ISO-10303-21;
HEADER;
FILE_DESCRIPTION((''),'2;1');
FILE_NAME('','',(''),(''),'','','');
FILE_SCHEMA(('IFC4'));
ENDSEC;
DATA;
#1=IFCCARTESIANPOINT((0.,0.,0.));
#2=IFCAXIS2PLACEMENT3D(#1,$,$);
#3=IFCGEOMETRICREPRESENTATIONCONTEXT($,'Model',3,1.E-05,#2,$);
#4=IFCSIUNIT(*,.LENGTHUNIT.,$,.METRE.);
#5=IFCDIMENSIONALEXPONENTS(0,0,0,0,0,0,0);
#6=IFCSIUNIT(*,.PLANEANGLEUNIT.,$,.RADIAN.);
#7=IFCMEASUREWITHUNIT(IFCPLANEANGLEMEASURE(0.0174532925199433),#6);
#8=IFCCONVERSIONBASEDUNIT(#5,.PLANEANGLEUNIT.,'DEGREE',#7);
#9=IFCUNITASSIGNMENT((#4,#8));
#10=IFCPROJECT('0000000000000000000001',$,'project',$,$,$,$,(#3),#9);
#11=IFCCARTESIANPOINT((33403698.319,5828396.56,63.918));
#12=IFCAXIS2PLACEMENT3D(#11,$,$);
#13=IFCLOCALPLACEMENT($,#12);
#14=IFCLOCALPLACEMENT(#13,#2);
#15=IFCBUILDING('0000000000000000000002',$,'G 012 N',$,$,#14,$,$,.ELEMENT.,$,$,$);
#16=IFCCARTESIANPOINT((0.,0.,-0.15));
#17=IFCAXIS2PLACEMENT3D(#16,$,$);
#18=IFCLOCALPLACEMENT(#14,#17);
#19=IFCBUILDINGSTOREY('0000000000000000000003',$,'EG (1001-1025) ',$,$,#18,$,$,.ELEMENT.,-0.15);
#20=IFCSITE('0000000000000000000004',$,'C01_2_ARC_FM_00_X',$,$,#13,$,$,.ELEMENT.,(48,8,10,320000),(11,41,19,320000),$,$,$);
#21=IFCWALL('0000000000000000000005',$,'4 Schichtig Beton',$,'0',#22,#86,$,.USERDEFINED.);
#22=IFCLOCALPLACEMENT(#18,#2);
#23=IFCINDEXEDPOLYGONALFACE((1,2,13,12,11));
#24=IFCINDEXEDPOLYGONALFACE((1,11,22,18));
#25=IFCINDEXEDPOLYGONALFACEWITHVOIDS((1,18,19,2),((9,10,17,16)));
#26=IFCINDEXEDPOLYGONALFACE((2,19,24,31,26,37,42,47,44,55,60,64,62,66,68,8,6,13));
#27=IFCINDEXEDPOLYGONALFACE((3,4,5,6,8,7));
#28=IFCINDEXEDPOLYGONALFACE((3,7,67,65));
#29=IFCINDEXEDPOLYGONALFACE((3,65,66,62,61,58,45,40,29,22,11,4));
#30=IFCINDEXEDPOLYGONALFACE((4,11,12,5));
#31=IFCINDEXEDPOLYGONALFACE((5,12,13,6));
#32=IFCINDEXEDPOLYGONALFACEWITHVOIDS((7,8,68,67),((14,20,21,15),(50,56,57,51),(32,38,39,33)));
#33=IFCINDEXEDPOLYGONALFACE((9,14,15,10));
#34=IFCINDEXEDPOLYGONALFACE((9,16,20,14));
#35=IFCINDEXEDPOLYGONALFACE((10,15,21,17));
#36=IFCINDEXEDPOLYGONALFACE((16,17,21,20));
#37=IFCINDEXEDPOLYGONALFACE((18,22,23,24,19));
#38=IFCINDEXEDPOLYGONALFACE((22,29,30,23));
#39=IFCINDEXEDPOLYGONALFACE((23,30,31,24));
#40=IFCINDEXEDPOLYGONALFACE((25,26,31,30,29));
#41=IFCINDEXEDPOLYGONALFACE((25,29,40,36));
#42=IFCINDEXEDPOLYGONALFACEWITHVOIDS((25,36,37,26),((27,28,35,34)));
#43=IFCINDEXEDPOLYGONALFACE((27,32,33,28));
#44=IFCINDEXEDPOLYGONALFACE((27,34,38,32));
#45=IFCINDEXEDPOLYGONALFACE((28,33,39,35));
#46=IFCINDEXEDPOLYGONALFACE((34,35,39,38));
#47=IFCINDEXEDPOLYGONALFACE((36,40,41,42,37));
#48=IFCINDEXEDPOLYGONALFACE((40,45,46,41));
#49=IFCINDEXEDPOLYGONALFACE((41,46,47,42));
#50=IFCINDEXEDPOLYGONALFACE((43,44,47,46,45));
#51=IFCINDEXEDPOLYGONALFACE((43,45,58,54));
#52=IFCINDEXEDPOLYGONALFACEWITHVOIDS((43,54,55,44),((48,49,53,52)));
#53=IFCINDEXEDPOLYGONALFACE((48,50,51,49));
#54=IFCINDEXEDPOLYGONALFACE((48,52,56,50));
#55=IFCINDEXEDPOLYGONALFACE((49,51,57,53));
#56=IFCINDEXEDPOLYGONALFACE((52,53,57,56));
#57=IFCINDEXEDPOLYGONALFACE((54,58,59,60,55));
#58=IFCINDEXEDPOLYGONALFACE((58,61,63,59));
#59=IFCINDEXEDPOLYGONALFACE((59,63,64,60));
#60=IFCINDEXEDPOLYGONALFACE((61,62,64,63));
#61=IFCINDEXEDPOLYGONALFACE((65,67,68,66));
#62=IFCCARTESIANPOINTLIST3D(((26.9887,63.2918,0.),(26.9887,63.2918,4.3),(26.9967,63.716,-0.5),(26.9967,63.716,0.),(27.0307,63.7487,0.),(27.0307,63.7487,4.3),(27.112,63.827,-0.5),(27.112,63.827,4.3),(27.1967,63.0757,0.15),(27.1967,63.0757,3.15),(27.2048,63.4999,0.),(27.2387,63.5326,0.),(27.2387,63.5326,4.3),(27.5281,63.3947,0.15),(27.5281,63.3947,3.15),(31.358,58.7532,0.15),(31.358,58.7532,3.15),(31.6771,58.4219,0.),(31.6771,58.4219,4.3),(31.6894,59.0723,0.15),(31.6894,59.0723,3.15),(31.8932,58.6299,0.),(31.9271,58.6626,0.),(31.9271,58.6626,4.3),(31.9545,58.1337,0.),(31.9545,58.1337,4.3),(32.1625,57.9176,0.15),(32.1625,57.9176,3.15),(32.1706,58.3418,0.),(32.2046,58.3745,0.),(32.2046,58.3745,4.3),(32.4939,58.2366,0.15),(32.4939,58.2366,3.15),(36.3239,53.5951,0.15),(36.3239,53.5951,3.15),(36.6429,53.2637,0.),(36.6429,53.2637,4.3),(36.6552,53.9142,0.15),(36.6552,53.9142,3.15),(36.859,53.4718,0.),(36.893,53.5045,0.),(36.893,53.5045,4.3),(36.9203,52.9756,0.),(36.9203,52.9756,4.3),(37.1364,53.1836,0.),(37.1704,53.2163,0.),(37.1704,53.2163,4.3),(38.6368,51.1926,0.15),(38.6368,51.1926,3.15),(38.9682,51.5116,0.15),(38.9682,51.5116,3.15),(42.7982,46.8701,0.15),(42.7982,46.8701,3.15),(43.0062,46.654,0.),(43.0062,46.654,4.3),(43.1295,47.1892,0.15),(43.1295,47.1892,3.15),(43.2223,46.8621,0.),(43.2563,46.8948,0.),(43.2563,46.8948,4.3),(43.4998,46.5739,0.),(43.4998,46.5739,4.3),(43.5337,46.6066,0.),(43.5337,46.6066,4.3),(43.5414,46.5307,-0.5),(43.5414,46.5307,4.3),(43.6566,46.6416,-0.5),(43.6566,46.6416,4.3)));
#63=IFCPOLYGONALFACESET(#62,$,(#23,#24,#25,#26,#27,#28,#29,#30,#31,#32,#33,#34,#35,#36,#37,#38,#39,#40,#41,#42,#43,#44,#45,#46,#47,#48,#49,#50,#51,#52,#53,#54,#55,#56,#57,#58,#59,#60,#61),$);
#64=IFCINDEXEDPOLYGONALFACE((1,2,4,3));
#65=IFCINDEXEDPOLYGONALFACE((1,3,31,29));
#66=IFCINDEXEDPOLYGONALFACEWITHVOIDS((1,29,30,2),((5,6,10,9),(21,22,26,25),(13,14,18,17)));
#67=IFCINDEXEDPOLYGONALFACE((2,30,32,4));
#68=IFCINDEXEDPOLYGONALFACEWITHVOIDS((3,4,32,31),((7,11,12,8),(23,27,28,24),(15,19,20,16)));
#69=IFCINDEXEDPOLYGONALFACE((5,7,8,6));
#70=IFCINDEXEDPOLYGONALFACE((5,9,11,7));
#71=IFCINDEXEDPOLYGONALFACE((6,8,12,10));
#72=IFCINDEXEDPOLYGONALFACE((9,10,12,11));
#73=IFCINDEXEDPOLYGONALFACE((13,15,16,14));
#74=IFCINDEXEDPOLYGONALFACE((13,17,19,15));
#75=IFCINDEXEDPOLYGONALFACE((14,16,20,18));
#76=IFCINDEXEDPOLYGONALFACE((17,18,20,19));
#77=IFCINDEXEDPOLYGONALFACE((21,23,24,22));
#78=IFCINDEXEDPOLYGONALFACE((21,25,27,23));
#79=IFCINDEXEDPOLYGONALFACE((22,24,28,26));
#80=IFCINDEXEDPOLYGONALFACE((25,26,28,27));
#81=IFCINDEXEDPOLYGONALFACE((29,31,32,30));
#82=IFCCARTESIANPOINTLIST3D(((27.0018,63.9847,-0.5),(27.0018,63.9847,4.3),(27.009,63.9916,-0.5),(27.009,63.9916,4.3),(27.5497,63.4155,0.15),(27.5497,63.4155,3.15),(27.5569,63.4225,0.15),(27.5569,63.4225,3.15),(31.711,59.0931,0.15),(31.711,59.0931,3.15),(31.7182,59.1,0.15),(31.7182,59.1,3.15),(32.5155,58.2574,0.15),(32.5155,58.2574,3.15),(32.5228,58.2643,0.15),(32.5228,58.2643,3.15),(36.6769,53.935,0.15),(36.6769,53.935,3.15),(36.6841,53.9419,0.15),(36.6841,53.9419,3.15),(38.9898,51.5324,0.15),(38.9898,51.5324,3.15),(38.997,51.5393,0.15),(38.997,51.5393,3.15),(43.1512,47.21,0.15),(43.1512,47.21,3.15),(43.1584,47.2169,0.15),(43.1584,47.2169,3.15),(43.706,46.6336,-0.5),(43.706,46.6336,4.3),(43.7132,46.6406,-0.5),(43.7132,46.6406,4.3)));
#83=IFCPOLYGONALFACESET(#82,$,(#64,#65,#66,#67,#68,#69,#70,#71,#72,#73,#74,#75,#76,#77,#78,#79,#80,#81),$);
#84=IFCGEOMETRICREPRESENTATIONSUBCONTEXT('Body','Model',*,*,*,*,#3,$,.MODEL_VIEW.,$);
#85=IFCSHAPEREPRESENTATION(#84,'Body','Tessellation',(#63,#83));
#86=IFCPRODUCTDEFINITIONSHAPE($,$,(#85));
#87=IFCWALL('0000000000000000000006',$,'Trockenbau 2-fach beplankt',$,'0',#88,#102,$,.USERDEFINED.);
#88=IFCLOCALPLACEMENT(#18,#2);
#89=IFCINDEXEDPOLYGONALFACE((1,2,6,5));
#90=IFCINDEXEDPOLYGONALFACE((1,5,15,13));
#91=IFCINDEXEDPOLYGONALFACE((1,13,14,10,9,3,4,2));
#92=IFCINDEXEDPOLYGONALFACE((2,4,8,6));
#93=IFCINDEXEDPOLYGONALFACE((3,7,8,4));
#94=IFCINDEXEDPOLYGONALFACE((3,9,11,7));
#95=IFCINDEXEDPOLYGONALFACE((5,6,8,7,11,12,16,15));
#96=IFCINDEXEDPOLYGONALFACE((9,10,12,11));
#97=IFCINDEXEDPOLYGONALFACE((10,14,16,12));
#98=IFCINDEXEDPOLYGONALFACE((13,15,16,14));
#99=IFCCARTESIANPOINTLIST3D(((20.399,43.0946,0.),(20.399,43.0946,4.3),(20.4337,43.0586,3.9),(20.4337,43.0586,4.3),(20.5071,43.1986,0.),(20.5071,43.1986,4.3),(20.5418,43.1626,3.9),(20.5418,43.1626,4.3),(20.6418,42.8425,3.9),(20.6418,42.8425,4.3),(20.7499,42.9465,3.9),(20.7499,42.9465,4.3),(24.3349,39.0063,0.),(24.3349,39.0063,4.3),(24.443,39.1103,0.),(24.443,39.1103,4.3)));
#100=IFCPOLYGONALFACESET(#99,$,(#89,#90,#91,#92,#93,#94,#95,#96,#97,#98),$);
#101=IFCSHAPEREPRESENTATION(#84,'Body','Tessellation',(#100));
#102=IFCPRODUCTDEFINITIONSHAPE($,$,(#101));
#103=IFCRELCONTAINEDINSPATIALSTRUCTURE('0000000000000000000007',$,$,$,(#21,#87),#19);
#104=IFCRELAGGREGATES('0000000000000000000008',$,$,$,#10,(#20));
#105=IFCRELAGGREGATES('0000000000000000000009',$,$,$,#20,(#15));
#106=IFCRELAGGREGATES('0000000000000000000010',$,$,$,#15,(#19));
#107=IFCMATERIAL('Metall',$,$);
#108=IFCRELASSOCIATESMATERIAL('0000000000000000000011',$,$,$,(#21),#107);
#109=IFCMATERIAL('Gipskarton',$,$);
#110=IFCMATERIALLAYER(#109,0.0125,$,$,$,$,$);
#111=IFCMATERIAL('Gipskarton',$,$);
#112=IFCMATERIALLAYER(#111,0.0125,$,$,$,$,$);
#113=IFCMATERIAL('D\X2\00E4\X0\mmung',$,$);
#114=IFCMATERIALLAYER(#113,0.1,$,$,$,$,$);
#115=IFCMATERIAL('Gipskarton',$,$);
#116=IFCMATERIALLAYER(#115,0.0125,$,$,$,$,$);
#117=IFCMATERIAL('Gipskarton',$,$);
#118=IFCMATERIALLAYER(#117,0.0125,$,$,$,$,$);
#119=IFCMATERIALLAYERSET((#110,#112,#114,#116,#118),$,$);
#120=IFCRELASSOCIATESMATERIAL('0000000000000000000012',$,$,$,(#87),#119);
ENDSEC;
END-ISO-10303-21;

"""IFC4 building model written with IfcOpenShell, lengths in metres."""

from ifc_helpers import new_model, entity, si_unit, converted_unit, frame, frame_2d, origin, origin_with_axes, place, context, subcontext, project, spatial, polyline, rectangle, outline, extrude, clip, bounded_halfspace, material, layer, layer_set, layer_usage, element, save


model = new_model("IFC4")

# Units and contexts
model_context = context("Model", 3, precision=1e-05, world=origin())
body_context = subcontext(model_context, "Body", "Model", "MODEL_VIEW")
ifc_project = project(units=[si_unit("LENGTHUNIT", "METRE"), converted_unit("PLANEANGLEUNIT", "DEGREE", entity("IfcPlaneAngleMeasure", 0.0174532925199433), si_unit("PLANEANGLEUNIT", "RADIAN"), dimensions=[0, 0, 0, 0, 0, 0, 0])], contexts=[model_context])

# Site, building, storey
site_placement = place(None, frame((33403698.319, 5828396.56, 63.918)))
site = spatial("IfcSite", under=ifc_project, at=site_placement, Name="C01_2_ARC_FM_00_X", CompositionType="ELEMENT", RefLatitude=(48, 8, 10, 320000), RefLongitude=(11, 41, 19, 320000))
building_placement = place(site_placement, origin())
building = spatial("IfcBuilding", under=site, at=building_placement, Name="G 012 N", CompositionType="ELEMENT")
storey_placement = place(building_placement, frame((0.0, 0.0, -0.15)))
storey = spatial("IfcBuildingStorey", under=building, at=storey_placement, Name="EG (1001-1025) ", CompositionType="ELEMENT", Elevation=-0.15)

# Wall, openings
ifc_material_1 = material(Name="Metall")
wall_1_placement = place(storey_placement, frame((43.7132, 46.6406, -0.5), z_axis=(0.0, 0.0, 1.0), x_axis=(-0.693551, 0.720408, 0.0)))
wall_1 = element("IfcWall", 1, at=wall_1_placement, inside=storey, material=ifc_material_1, Name="4 Schichtig Beton", ObjectType="0", PredefinedType="USERDEFINED", context=body_context, shape_type="Clipping", body=[
    clip(clip(clip(clip(clip(clip(clip(extrude(outline(polyline([(12.0749, -11.9247), (12.0749, -11.6247), (5.3149, -11.6247), (5.3149, -11.9247), (4.9149, -11.9247), (4.9149, -11.6247), (-1.8451, -11.6247), (-1.8451, -11.9247), (-2.2451, -11.9247), (-2.2451, -11.6247), (-11.0201, -11.6247), (-11.0201, -11.9247), (-11.4801, -11.9247), (-11.4801, -12.0847), (12.3749, -12.0847), (12.3749, -11.9247), (12.0749, -11.9247)])), frame((11.5201, 12.1247, 0.0), z_axis=(0.0, 0.0, 1.0), x_axis=(1.0, 0.0, 0.0)), (0.0, 0.0, 1.0), 4.8), bounded_halfspace(frame((4.8875, 0.35, 0.5), z_axis=(0.0, 0.0, 1.0), x_axis=(1.0, 0.0, 0.0)), True, origin_with_axes(), polyline([(0.5, 0.2), (9.275, 0.2), (9.275, 0.5), (0.5, 0.5), (0.5, 0.2)]))), bounded_halfspace(frame((20.215, 0.35, 0.5), z_axis=(0.0, 0.0, 1.0), x_axis=(1.0, 0.0, 0.0)), True, origin_with_axes(), polyline([(16.835, 0.2), (23.595, 0.2), (23.595, 0.5), (16.835, 0.5), (16.835, 0.2)]))), bounded_halfspace(frame((13.055, 0.35, 0.5), z_axis=(0.0, 0.0, 1.0), x_axis=(1.0, 0.0, 0.0)), True, origin_with_axes(), polyline([(9.675, 0.2), (16.435, 0.2), (16.435, 0.5), (9.675, 0.5), (9.675, 0.2)]))), bounded_halfspace(frame((0.3, 0.1764, 0.5), z_axis=(0.0, 0.0, -1.0), x_axis=(-1.0, 0.0, 0.0)), True, origin_with_axes(), polyline([(0.5, 0.2), (0.1, 0.2), (0.1, 0.1529), (0.5, 0.1529), (0.5, 0.2)]))), bounded_halfspace(frame((23.745, 0.1764, 0.5), z_axis=(0.0, 0.0, -1.0), x_axis=(-1.0, 0.0, 0.0)), True, origin_with_axes(), polyline([(23.895, 0.2), (23.595, 0.2), (23.595, 0.1529), (23.895, 0.1529), (23.895, 0.2)]))), bounded_halfspace(frame((16.635, 0.1764, 0.5), z_axis=(0.0, 0.0, -1.0), x_axis=(-1.0, 0.0, 0.0)), True, origin_with_axes(), polyline([(16.835, 0.2), (16.435, 0.2), (16.435, 0.1529), (16.835, 0.1529), (16.835, 0.2)]))), bounded_halfspace(frame((9.475, 0.1764, 0.5), z_axis=(0.0, 0.0, -1.0), x_axis=(-1.0, 0.0, 0.0)), True, origin_with_axes(), polyline([(9.675, 0.2), (9.275, 0.2), (9.275, 0.1529), (9.675, 0.1529), (9.675, 0.2)]))),
    clip(clip(clip(clip(clip(clip(clip(extrude(rectangle(XDim=24.085, YDim=0.01, at=frame_2d((-12.0425, -0.005), x_axis=(-1.0, 0.0))), frame((24.085, 0.01, 0.0), z_axis=(0.0, 0.0, 1.0), x_axis=(1.0, 0.0, 0.0)), (0.0, 0.0, 1.0), 4.8), bounded_halfspace(frame((4.8875, 0.35, 0.5), z_axis=(0.0, 0.0, 1.0), x_axis=(1.0, 0.0, 0.0)), True, origin_with_axes(), polyline([(0.5, 0.2), (9.275, 0.2), (9.275, 0.5), (0.5, 0.5), (0.5, 0.2)]))), bounded_halfspace(frame((20.215, 0.35, 0.5), z_axis=(0.0, 0.0, 1.0), x_axis=(1.0, 0.0, 0.0)), True, origin_with_axes(), polyline([(16.835, 0.2), (23.595, 0.2), (23.595, 0.5), (16.835, 0.5), (16.835, 0.2)]))), bounded_halfspace(frame((13.055, 0.35, 0.5), z_axis=(0.0, 0.0, 1.0), x_axis=(1.0, 0.0, 0.0)), True, origin_with_axes(), polyline([(9.675, 0.2), (16.435, 0.2), (16.435, 0.5), (9.675, 0.5), (9.675, 0.2)]))), bounded_halfspace(frame((0.3, 0.1764, 0.5), z_axis=(0.0, 0.0, -1.0), x_axis=(-1.0, 0.0, 0.0)), True, origin_with_axes(), polyline([(0.5, 0.2), (0.1, 0.2), (0.1, 0.1529), (0.5, 0.1529), (0.5, 0.2)]))), bounded_halfspace(frame((23.745, 0.1764, 0.5), z_axis=(0.0, 0.0, -1.0), x_axis=(-1.0, 0.0, 0.0)), True, origin_with_axes(), polyline([(23.895, 0.2), (23.595, 0.2), (23.595, 0.1529), (23.895, 0.1529), (23.895, 0.2)]))), bounded_halfspace(frame((16.635, 0.1764, 0.5), z_axis=(0.0, 0.0, -1.0), x_axis=(-1.0, 0.0, 0.0)), True, origin_with_axes(), polyline([(16.835, 0.2), (16.435, 0.2), (16.435, 0.1529), (16.835, 0.1529), (16.835, 0.2)]))), bounded_halfspace(frame((9.475, 0.1764, 0.5), z_axis=(0.0, 0.0, -1.0), x_axis=(-1.0, 0.0, 0.0)), True, origin_with_axes(), polyline([(9.675, 0.2), (9.275, 0.2), (9.275, 0.1529), (9.675, 0.1529), (9.675, 0.2)]))),
])
opening_1_placement = place(wall_1_placement, frame((23.295, 0.01, 0.65), z_axis=(0.0, -1.0, 0.0), x_axis=(0.0, 0.0, 1.0)))
element("IfcOpeningElement", 2, at=opening_1_placement, cuts=wall_1, ObjectType="Opening", context=body_context, shape_type="SweptSolid", body=[
    extrude(outline(polyline([(0.0, 6.0), (3.0, 6.0), (3.0, 0.0), (0.0, 0.0), (0.0, 6.0)])), origin_with_axes(), (0.0, 0.0, 1.0), 0.01),
    extrude(outline(polyline([(0.0, 6.0), (3.0, 6.0), (3.0, 0.0), (0.0, 0.0), (0.0, 6.0)])), frame((0.0, 0.0, -0.03), z_axis=(0.0, 0.0, 1.0), x_axis=(1.0, 0.0, 0.0)), (0.0, 0.0, 1.0), 0.03),
    extrude(outline(polyline([(0.0, 6.0), (3.0, 6.0), (3.0, 0.0), (0.0, 0.0), (0.0, 6.0)])), frame((0.0, 0.0, -0.19), z_axis=(0.0, 0.0, 1.0), x_axis=(1.0, 0.0, 0.0)), (0.0, 0.0, 1.0), 0.16),
    extrude(outline(polyline([(0.0, 6.0), (3.0, 6.0), (3.0, 0.0), (0.0, 0.0), (0.0, 6.0)])), frame((0.0, 0.0, -0.49), z_axis=(0.0, 0.0, 1.0), x_axis=(1.0, 0.0, 0.0)), (0.0, 0.0, 1.0), 0.3),
])
opening_2_placement = place(wall_1_placement, frame((16.135, 0.01, 0.65), z_axis=(0.0, -1.0, 0.0), x_axis=(0.0, 0.0, 1.0)))
element("IfcOpeningElement", 3, at=opening_2_placement, cuts=wall_1, ObjectType="Opening", context=body_context, shape_type="SweptSolid", body=[
    extrude(outline(polyline([(0.0, 6.0), (3.0, 6.0), (3.0, 0.0), (0.0, 0.0), (0.0, 6.0)])), origin_with_axes(), (0.0, 0.0, 1.0), 0.01),
    extrude(outline(polyline([(0.0, 6.0), (3.0, 6.0), (3.0, 0.0), (0.0, 0.0), (0.0, 6.0)])), frame((0.0, 0.0, -0.03), z_axis=(0.0, 0.0, 1.0), x_axis=(1.0, 0.0, 0.0)), (0.0, 0.0, 1.0), 0.03),
    extrude(outline(polyline([(0.0, 6.0), (3.0, 6.0), (3.0, 0.0), (0.0, 0.0), (0.0, 6.0)])), frame((0.0, 0.0, -0.19), z_axis=(0.0, 0.0, 1.0), x_axis=(1.0, 0.0, 0.0)), (0.0, 0.0, 1.0), 0.16),
    extrude(outline(polyline([(0.0, 6.0), (3.0, 6.0), (3.0, 0.0), (0.0, 0.0), (0.0, 6.0)])), frame((0.0, 0.0, -0.49), z_axis=(0.0, 0.0, 1.0), x_axis=(1.0, 0.0, 0.0)), (0.0, 0.0, 1.0), 0.3),
])
opening_3_placement = place(wall_1_placement, frame((6.8, 0.01, 0.65), z_axis=(0.0, -1.0, 0.0), x_axis=(0.0, 0.0, 1.0)))
element("IfcOpeningElement", 4, at=opening_3_placement, cuts=wall_1, ObjectType="Opening", context=body_context, shape_type="SweptSolid", body=[
    extrude(outline(polyline([(0.0, 6.0), (3.0, 6.0), (3.0, 0.0), (0.0, 0.0), (0.0, 6.0)])), origin_with_axes(), (0.0, 0.0, 1.0), 0.01),
    extrude(outline(polyline([(0.0, 6.0), (3.0, 6.0), (3.0, 0.0), (0.0, 0.0), (0.0, 6.0)])), frame((0.0, 0.0, -0.03), z_axis=(0.0, 0.0, 1.0), x_axis=(1.0, 0.0, 0.0)), (0.0, 0.0, 1.0), 0.03),
    extrude(outline(polyline([(0.0, 6.0), (3.0, 6.0), (3.0, 0.0), (0.0, 0.0), (0.0, 6.0)])), frame((0.0, 0.0, -0.19), z_axis=(0.0, 0.0, 1.0), x_axis=(1.0, 0.0, 0.0)), (0.0, 0.0, 1.0), 0.16),
    extrude(outline(polyline([(0.0, 6.0), (3.0, 6.0), (3.0, 0.0), (0.0, 0.0), (0.0, 6.0)])), frame((0.0, 0.0, -0.49), z_axis=(0.0, 0.0, 1.0), x_axis=(1.0, 0.0, 0.0)), (0.0, 0.0, 1.0), 0.3),
])

# Wall
ifc_material_2 = material(Name="Gipskarton")
ifc_layer_1 = layer(ifc_material_2, 0.0125)
ifc_material_3 = material(Name="Gipskarton")
ifc_layer_2 = layer(ifc_material_3, 0.0125)
ifc_material_4 = material(Name="Dämmung")
ifc_layer_3 = layer(ifc_material_4, 0.1)
ifc_material_5 = material(Name="Gipskarton")
ifc_layer_4 = layer(ifc_material_5, 0.0125)
ifc_material_6 = material(Name="Gipskarton")
ifc_layer_5 = layer(ifc_material_6, 0.0125)
ifc_layer_set_1 = layer_set([ifc_layer_1, ifc_layer_2, ifc_layer_3, ifc_layer_4, ifc_layer_5])
ifc_layer_usage_1 = layer_usage(ifc_layer_set_1, "AXIS2", "POSITIVE", 0.0)
wall_2_placement = place(storey_placement, frame((20.399, 43.0946, 0.0), z_axis=(0.0, 0.0, 1.0), x_axis=(0.693551, -0.720408, 0.0)))
element("IfcWall", 5, at=wall_2_placement, inside=storey, material=ifc_layer_usage_1, Name="Trockenbau 2-fach beplankt", ObjectType="0", PredefinedType="USERDEFINED", context=body_context, shape_type="Clipping", body=[
    clip(extrude(rectangle(XDim=5.675, YDim=0.15, at=frame_2d((2.8375, 0.075), x_axis=(1.0, 0.0))), origin_with_axes(), (0.0, 0.0, 1.0), 4.3), bounded_halfspace(frame((0.2, 0.075, 3.9), z_axis=(0.0, 0.0, -1.0), x_axis=(1.0, 0.0, 0.0)), True, origin_with_axes(), polyline([(0.05, 0.0), (0.35, 0.0), (0.35, 0.15), (0.05, 0.15), (0.05, 0.0)]))),
])

save(model, "model.ifc")
